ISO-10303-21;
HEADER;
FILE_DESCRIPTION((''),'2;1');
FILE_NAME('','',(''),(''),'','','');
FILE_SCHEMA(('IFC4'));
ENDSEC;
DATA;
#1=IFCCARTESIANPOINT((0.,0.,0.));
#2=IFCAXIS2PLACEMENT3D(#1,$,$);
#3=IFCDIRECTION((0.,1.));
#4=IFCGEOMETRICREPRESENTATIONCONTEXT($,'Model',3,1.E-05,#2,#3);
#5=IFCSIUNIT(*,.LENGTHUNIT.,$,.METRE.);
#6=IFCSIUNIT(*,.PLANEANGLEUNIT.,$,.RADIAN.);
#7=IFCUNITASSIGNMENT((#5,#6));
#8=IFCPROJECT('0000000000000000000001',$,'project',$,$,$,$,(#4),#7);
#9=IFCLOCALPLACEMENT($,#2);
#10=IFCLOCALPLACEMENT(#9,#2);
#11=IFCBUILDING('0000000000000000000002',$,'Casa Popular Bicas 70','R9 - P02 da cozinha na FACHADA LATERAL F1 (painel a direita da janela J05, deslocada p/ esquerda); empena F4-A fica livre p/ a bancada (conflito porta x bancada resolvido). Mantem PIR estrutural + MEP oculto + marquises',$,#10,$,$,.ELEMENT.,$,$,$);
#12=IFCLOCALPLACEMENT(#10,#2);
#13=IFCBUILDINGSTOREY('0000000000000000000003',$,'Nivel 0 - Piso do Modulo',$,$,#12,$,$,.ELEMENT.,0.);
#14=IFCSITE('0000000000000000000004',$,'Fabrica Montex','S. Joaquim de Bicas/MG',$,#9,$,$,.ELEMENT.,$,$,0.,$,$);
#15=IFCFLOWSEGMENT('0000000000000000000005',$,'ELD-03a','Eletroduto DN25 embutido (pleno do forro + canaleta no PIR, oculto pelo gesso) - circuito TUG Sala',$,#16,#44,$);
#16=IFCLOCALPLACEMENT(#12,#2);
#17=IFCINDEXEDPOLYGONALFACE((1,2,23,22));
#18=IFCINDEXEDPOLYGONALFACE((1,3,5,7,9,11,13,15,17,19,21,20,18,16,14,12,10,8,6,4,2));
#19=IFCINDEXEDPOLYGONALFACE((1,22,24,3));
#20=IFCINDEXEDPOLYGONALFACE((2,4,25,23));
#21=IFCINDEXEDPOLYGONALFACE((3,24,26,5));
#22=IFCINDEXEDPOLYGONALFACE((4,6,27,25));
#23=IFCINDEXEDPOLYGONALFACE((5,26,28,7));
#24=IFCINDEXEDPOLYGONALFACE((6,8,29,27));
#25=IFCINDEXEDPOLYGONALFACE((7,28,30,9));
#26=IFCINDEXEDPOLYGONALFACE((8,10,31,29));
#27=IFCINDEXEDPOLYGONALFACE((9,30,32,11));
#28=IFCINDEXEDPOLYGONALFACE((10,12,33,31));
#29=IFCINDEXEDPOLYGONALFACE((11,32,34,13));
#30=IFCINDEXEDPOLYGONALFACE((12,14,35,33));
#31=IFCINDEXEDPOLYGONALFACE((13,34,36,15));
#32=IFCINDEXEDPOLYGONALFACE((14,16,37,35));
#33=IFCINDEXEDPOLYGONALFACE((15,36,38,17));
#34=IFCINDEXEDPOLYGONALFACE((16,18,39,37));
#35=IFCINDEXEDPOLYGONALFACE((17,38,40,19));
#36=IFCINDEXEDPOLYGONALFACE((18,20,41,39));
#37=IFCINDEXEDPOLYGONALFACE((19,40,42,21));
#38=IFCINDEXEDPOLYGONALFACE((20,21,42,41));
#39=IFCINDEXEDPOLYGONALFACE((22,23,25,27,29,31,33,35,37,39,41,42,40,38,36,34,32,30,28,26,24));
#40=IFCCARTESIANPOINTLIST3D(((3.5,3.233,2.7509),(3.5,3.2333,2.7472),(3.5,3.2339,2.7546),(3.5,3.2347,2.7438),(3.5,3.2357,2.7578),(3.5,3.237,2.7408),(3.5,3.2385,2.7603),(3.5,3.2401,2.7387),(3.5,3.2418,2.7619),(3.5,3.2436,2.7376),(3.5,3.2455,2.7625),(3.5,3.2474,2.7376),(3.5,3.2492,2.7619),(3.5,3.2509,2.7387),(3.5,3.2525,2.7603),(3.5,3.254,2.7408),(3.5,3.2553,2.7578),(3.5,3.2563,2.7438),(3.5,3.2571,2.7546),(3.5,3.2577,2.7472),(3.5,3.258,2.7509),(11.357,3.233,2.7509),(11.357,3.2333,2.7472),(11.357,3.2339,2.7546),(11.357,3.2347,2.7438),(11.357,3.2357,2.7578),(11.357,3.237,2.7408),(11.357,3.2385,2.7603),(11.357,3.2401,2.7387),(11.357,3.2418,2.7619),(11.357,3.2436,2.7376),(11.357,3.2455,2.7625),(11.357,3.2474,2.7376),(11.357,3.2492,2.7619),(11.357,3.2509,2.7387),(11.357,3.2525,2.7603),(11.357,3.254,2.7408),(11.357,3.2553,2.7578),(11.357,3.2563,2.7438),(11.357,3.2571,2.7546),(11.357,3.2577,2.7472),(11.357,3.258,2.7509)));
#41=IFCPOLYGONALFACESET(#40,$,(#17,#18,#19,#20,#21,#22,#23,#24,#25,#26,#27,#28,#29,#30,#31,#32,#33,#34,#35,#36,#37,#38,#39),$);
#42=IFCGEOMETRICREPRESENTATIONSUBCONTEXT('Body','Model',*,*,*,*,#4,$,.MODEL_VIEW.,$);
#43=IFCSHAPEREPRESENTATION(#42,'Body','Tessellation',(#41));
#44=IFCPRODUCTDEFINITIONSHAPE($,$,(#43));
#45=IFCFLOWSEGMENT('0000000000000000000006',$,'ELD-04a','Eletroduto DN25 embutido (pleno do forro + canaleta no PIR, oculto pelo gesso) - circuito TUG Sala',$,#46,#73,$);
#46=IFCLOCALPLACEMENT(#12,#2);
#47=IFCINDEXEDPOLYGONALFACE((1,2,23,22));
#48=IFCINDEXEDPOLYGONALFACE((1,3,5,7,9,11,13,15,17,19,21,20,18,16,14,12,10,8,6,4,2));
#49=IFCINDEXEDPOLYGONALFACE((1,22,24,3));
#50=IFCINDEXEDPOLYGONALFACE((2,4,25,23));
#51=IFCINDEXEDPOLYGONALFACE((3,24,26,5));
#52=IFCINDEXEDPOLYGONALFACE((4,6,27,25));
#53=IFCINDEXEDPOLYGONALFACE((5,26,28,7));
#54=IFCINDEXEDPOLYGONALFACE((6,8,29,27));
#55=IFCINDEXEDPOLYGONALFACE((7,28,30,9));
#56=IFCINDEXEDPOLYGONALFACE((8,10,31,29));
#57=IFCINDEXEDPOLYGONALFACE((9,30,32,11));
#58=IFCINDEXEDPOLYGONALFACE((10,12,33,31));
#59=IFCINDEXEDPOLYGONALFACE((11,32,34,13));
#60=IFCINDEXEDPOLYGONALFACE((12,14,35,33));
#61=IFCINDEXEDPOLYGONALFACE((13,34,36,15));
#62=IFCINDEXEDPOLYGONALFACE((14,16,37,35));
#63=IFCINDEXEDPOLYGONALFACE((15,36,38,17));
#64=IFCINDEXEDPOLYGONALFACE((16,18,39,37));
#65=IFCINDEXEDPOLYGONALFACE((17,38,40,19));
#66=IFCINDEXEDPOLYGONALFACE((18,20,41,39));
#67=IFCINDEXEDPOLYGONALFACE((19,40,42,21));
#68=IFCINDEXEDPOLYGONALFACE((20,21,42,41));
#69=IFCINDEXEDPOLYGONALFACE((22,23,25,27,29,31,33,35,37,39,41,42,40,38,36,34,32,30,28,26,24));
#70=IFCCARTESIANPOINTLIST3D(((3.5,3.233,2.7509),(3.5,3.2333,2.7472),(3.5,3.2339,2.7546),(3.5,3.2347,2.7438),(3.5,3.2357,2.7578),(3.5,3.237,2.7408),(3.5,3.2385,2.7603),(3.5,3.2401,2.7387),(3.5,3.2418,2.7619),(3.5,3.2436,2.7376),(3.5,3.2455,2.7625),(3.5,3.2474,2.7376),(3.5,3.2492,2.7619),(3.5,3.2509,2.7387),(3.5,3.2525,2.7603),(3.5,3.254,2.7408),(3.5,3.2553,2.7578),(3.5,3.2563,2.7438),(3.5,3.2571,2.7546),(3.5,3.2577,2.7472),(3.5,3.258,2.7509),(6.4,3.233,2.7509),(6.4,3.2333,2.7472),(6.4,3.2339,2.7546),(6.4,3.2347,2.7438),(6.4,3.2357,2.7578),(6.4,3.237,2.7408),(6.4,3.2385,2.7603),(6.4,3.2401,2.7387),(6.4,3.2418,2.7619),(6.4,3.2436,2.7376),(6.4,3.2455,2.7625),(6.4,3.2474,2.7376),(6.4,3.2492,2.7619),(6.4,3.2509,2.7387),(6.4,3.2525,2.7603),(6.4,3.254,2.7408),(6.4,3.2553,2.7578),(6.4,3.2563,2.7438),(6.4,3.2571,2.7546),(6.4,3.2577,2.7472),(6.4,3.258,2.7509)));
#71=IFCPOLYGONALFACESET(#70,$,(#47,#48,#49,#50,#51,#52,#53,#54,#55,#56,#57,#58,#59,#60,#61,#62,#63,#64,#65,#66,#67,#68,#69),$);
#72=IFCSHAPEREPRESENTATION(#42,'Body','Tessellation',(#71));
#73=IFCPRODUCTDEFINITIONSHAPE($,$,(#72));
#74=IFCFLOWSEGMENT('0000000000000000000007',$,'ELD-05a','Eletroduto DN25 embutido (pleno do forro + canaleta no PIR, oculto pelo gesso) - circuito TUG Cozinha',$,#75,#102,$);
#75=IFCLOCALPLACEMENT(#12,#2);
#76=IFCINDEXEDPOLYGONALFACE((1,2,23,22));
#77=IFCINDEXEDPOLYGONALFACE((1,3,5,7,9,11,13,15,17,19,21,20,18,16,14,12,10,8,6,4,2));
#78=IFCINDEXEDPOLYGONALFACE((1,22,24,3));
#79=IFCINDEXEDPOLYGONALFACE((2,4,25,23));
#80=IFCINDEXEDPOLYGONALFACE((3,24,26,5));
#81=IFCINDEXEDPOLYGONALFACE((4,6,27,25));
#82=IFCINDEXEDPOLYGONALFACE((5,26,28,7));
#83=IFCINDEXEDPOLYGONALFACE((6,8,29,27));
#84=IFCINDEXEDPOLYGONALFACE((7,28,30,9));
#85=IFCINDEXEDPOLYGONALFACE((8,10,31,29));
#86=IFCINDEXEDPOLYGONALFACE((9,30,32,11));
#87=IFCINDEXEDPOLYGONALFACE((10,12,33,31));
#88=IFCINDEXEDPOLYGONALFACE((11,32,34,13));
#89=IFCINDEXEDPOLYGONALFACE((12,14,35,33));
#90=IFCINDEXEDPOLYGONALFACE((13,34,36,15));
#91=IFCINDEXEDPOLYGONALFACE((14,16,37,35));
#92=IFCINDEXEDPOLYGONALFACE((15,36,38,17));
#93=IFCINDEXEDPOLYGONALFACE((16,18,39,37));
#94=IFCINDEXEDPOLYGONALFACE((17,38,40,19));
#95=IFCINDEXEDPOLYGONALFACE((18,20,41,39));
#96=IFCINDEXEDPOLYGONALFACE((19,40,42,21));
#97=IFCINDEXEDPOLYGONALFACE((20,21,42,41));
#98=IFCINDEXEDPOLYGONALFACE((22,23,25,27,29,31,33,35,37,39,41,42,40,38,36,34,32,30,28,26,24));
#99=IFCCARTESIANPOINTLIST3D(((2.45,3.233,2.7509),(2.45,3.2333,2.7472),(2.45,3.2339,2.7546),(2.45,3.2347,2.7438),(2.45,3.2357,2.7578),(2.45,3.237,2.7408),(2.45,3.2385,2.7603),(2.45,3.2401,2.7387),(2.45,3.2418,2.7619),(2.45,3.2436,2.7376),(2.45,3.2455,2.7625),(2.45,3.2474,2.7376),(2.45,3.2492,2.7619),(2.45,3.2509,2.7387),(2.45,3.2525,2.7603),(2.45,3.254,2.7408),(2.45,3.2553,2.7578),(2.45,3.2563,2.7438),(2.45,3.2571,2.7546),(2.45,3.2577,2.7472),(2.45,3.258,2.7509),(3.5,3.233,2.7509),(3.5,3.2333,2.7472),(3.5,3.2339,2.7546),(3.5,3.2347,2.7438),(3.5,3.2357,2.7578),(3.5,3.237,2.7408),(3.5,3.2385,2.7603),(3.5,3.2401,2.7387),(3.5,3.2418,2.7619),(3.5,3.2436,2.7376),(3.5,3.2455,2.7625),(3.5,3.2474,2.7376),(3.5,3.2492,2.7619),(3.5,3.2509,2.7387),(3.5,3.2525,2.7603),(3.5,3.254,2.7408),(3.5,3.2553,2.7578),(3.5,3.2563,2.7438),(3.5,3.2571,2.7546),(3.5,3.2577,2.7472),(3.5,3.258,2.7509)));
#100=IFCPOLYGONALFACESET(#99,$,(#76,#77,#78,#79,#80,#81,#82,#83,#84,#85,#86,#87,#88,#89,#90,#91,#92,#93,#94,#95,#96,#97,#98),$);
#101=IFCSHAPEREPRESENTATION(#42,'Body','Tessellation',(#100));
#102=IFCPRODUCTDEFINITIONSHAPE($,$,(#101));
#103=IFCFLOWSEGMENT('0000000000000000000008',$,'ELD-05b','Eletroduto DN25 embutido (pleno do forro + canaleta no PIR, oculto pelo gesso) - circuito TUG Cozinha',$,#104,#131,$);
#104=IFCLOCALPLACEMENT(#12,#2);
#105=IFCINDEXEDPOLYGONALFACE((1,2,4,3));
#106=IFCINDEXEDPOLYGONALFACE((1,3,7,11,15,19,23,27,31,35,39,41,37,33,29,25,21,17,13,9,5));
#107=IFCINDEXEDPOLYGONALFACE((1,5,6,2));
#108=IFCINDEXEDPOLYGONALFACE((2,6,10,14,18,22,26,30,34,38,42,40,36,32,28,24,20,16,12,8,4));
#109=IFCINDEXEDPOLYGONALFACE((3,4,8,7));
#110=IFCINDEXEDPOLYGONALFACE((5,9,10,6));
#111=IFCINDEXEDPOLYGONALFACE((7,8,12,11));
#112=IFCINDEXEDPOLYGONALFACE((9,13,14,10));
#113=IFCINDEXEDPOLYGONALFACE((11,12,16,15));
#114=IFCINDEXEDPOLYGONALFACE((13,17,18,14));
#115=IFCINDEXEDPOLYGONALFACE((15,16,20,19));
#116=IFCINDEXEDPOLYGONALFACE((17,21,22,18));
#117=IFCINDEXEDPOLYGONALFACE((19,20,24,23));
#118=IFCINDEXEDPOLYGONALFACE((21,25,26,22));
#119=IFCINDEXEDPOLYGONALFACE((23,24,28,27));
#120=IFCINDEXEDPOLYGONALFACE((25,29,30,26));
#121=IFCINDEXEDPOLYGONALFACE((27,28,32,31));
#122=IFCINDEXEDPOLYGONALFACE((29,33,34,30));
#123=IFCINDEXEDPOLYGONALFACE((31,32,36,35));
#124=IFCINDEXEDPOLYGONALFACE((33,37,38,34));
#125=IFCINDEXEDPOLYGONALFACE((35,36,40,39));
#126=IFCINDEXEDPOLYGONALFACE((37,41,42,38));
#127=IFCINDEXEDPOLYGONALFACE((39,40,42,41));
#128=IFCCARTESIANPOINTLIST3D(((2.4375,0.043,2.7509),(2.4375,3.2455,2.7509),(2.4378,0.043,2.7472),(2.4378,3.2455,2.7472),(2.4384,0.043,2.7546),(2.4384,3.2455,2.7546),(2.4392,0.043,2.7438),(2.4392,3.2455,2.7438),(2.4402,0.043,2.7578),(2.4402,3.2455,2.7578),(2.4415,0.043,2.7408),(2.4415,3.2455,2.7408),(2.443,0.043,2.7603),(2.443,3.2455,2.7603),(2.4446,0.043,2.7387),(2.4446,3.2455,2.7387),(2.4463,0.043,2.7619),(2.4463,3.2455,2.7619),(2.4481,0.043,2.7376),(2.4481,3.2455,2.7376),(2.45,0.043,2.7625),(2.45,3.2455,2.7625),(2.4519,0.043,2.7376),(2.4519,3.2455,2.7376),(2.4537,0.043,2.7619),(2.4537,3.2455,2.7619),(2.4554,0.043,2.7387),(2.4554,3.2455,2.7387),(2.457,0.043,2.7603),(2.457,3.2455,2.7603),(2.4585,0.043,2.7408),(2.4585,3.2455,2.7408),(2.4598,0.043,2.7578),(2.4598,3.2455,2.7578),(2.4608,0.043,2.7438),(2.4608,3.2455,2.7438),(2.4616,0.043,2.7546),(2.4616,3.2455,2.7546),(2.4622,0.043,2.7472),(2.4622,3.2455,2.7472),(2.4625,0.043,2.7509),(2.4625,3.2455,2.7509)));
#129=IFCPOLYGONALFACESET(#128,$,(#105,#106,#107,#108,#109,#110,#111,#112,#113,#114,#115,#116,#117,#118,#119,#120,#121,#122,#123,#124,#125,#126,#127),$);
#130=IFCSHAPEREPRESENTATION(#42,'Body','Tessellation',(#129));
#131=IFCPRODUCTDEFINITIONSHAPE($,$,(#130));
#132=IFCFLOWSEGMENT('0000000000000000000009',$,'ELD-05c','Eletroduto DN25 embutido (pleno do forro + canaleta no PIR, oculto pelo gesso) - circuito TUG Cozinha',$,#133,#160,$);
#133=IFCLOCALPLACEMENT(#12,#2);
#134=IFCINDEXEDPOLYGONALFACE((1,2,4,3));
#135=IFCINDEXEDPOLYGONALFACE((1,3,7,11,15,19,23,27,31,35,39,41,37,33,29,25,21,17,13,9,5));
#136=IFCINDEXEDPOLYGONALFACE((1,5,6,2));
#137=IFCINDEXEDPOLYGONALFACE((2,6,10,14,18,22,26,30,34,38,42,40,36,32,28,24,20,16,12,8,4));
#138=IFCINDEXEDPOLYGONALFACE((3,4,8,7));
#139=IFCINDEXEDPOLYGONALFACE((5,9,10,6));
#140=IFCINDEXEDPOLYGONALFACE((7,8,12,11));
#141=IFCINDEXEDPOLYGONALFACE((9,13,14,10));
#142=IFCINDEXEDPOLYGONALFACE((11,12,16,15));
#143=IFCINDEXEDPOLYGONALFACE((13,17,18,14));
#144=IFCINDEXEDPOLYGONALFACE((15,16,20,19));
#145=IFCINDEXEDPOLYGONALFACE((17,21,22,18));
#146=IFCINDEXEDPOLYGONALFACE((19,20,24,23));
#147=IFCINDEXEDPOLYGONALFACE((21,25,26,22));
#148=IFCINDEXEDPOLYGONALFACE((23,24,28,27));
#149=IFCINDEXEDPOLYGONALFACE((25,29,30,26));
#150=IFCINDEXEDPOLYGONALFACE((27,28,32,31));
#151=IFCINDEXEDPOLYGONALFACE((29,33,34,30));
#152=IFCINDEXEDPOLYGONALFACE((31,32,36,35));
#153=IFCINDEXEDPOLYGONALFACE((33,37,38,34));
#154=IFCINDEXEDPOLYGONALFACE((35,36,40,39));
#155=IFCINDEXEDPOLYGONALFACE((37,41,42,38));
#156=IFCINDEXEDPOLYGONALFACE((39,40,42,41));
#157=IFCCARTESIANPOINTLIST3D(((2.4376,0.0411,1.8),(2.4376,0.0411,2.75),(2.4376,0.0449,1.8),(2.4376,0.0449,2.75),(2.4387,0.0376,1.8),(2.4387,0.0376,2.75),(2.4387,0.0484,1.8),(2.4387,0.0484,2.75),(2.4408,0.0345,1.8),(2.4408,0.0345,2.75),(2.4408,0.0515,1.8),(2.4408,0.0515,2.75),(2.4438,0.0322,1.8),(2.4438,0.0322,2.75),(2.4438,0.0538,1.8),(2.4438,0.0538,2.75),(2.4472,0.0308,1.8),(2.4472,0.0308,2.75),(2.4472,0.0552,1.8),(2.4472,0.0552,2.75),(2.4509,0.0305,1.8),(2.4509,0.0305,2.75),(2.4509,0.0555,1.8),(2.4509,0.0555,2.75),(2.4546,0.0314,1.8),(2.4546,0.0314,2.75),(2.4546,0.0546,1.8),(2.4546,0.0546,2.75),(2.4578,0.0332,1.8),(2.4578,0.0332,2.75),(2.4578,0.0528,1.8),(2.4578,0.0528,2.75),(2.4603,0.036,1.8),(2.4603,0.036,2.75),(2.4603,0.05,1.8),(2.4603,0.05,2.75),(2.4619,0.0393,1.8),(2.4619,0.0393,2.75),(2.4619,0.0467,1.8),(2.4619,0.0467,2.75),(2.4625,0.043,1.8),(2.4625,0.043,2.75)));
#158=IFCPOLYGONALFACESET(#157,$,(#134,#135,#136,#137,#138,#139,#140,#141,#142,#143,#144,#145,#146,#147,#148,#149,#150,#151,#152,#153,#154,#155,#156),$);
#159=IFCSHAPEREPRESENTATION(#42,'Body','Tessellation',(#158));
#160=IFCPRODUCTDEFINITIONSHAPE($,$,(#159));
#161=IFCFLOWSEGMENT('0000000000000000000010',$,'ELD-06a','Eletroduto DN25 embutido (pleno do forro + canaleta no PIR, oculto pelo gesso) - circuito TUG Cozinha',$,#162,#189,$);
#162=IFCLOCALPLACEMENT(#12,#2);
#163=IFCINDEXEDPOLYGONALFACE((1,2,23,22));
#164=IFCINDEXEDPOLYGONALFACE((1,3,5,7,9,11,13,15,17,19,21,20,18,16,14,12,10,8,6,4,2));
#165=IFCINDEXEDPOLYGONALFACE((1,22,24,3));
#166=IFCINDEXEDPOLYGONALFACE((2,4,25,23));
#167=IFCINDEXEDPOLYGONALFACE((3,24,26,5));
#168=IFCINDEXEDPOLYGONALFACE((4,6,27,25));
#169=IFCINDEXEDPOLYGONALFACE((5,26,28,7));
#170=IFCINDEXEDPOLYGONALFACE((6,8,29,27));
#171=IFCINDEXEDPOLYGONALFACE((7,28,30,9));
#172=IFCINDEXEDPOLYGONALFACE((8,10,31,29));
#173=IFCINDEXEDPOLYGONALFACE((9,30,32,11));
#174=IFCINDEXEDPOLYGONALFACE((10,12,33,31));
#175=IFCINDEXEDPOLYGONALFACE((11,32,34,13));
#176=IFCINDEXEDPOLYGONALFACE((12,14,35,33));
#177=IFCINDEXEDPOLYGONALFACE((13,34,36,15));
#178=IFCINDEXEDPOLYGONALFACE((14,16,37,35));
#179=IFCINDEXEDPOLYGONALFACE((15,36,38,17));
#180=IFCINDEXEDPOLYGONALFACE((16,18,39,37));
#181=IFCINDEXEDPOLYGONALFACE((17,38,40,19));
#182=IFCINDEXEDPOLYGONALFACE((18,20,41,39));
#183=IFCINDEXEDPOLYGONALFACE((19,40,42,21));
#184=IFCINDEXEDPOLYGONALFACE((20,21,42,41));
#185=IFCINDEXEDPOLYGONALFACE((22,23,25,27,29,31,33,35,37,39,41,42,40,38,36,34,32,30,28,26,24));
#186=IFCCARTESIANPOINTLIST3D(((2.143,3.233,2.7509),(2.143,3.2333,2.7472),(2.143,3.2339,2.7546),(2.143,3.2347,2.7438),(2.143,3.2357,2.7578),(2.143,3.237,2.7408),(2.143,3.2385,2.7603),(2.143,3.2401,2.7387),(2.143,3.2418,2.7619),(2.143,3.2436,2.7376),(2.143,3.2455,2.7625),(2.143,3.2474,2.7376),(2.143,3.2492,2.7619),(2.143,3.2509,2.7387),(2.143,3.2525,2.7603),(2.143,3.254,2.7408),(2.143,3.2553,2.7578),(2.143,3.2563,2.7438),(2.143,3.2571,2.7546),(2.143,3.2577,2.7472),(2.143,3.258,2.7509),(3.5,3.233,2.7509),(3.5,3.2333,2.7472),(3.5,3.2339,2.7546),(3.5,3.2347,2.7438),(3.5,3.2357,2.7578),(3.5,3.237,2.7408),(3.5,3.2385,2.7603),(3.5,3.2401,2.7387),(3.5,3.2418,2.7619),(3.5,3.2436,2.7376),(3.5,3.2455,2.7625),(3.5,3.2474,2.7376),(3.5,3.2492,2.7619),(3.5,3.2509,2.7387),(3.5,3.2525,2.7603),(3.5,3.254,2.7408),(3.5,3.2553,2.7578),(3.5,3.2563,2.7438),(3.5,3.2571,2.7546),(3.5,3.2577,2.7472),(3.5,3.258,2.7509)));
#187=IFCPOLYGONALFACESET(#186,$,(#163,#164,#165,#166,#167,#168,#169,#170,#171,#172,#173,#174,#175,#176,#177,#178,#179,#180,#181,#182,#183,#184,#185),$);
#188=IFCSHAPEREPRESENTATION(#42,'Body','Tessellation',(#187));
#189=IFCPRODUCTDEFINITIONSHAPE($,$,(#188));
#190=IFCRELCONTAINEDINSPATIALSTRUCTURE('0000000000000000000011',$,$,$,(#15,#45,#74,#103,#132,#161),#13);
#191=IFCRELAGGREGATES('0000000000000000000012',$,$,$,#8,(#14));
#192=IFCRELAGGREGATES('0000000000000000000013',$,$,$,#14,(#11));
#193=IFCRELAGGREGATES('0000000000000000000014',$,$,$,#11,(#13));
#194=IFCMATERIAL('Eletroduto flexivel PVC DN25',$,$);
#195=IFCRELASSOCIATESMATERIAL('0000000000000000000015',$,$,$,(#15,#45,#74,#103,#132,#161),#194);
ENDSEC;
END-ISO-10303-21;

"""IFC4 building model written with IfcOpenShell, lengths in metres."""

from ifc_helpers import new_model, si_unit, direction, frame, origin, origin_2d, place, context, subcontext, project, spatial, circle, extrude, material, element, save


model = new_model("IFC4")

# Units and contexts
model_context = context("Model", 3, precision=1e-05, world=origin(), true_north=direction((0.0, 1.0)))
body_context = subcontext(model_context, "Body", "Model", "MODEL_VIEW")
ifc_project = project(units=[si_unit("LENGTHUNIT", "METRE"), si_unit("PLANEANGLEUNIT", "RADIAN")], contexts=[model_context])

# Site, building, storey
site_placement = place(None, origin())
site = spatial("IfcSite", under=ifc_project, at=site_placement, Name="Fabrica Montex", Description="S. Joaquim de Bicas/MG", CompositionType="ELEMENT", RefElevation=0.0)
building_placement = place(site_placement, origin())
building = spatial("IfcBuilding", under=site, at=building_placement, Name="Casa Popular Bicas 70", Description="R9 - P02 da cozinha na FACHADA LATERAL F1 (painel a direita da janela J05, deslocada p/ esquerda); empena F4-A fica livre p/ a bancada (conflito porta x bancada resolvido). Mantem PIR estrutural + MEP oculto + marquises", CompositionType="ELEMENT")
storey_placement = place(building_placement, origin())
storey = spatial("IfcBuildingStorey", under=building, at=storey_placement, Name="Nivel 0 - Piso do Modulo", CompositionType="ELEMENT", Elevation=0.0)

# Flow segments
ifc_material_1 = material(Name="Eletroduto flexivel PVC DN25")
flow_segment_1_placement = place(storey_placement, frame((3.5, 3.2455, 2.75), z_axis=(1.0, 0.0, 0.0), x_axis=(0.0, 0.0, 1.0)))
element("IfcFlowSegment", 1, at=flow_segment_1_placement, inside=storey, material=ifc_material_1, Name="ELD-03a", Description="Eletroduto DN25 embutido (pleno do forro + canaleta no PIR, oculto pelo gesso) - circuito TUG Sala", context=body_context, shape_type="SweptSolid", body=[
    extrude(circle(Radius=0.0125, at=origin_2d()), origin(), (0.0, 0.0, 1.0), 7.857),
])
flow_segment_2_placement = place(storey_placement, frame((3.5, 3.2455, 2.75), z_axis=(1.0, 0.0, 0.0), x_axis=(0.0, 0.0, 1.0)))
element("IfcFlowSegment", 2, at=flow_segment_2_placement, inside=storey, material=ifc_material_1, Name="ELD-04a", Description="Eletroduto DN25 embutido (pleno do forro + canaleta no PIR, oculto pelo gesso) - circuito TUG Sala", context=body_context, shape_type="SweptSolid", body=[
    extrude(circle(Radius=0.0125, at=origin_2d()), origin(), (0.0, 0.0, 1.0), 2.9),
])
flow_segment_3_placement = place(storey_placement, frame((3.5, 3.2455, 2.75), z_axis=(-1.0, 0.0, 0.0), x_axis=(0.0, 0.0, 1.0)))
element("IfcFlowSegment", 3, at=flow_segment_3_placement, inside=storey, material=ifc_material_1, Name="ELD-05a", Description="Eletroduto DN25 embutido (pleno do forro + canaleta no PIR, oculto pelo gesso) - circuito TUG Cozinha", context=body_context, shape_type="SweptSolid", body=[
    extrude(circle(Radius=0.0125, at=origin_2d()), origin(), (0.0, 0.0, 1.0), 1.05),
])
flow_segment_4_placement = place(storey_placement, frame((2.45, 3.2455, 2.75), z_axis=(0.0, -1.0, 0.0), x_axis=(0.0, 0.0, 1.0)))
element("IfcFlowSegment", 4, at=flow_segment_4_placement, inside=storey, material=ifc_material_1, Name="ELD-05b", Description="Eletroduto DN25 embutido (pleno do forro + canaleta no PIR, oculto pelo gesso) - circuito TUG Cozinha", context=body_context, shape_type="SweptSolid", body=[
    extrude(circle(Radius=0.0125, at=origin_2d()), origin(), (0.0, 0.0, 1.0), 3.2025),
])
flow_segment_5_placement = place(storey_placement, frame((2.45, 0.043, 2.75), z_axis=(0.0, 0.0, -1.0), x_axis=(1.0, 0.0, 0.0)))
element("IfcFlowSegment", 5, at=flow_segment_5_placement, inside=storey, material=ifc_material_1, Name="ELD-05c", Description="Eletroduto DN25 embutido (pleno do forro + canaleta no PIR, oculto pelo gesso) - circuito TUG Cozinha", context=body_context, shape_type="SweptSolid", body=[
    extrude(circle(Radius=0.0125, at=origin_2d()), origin(), (0.0, 0.0, 1.0), 0.95),
])
for number, where, z_axis, x_axis, name in (
    (6, (3.5, 3.2455, 2.75), (-1.0, 0.0, 0.0), (0.0, 0.0, 1.0), "ELD-06a"),
):
    element("IfcFlowSegment", number, at=place(storey_placement, frame(where, z_axis=z_axis, x_axis=x_axis)), inside=storey, material=ifc_material_1, Name=name, Description="Eletroduto DN25 embutido (pleno do forro + canaleta no PIR, oculto pelo gesso) - circuito TUG Cozinha", context=body_context, shape_type="SweptSolid", body=[
        extrude(circle(Radius=0.0125, at=origin_2d()), origin(), (0.0, 0.0, 1.0), 1.357),
    ])

save(model, "model.ifc")
